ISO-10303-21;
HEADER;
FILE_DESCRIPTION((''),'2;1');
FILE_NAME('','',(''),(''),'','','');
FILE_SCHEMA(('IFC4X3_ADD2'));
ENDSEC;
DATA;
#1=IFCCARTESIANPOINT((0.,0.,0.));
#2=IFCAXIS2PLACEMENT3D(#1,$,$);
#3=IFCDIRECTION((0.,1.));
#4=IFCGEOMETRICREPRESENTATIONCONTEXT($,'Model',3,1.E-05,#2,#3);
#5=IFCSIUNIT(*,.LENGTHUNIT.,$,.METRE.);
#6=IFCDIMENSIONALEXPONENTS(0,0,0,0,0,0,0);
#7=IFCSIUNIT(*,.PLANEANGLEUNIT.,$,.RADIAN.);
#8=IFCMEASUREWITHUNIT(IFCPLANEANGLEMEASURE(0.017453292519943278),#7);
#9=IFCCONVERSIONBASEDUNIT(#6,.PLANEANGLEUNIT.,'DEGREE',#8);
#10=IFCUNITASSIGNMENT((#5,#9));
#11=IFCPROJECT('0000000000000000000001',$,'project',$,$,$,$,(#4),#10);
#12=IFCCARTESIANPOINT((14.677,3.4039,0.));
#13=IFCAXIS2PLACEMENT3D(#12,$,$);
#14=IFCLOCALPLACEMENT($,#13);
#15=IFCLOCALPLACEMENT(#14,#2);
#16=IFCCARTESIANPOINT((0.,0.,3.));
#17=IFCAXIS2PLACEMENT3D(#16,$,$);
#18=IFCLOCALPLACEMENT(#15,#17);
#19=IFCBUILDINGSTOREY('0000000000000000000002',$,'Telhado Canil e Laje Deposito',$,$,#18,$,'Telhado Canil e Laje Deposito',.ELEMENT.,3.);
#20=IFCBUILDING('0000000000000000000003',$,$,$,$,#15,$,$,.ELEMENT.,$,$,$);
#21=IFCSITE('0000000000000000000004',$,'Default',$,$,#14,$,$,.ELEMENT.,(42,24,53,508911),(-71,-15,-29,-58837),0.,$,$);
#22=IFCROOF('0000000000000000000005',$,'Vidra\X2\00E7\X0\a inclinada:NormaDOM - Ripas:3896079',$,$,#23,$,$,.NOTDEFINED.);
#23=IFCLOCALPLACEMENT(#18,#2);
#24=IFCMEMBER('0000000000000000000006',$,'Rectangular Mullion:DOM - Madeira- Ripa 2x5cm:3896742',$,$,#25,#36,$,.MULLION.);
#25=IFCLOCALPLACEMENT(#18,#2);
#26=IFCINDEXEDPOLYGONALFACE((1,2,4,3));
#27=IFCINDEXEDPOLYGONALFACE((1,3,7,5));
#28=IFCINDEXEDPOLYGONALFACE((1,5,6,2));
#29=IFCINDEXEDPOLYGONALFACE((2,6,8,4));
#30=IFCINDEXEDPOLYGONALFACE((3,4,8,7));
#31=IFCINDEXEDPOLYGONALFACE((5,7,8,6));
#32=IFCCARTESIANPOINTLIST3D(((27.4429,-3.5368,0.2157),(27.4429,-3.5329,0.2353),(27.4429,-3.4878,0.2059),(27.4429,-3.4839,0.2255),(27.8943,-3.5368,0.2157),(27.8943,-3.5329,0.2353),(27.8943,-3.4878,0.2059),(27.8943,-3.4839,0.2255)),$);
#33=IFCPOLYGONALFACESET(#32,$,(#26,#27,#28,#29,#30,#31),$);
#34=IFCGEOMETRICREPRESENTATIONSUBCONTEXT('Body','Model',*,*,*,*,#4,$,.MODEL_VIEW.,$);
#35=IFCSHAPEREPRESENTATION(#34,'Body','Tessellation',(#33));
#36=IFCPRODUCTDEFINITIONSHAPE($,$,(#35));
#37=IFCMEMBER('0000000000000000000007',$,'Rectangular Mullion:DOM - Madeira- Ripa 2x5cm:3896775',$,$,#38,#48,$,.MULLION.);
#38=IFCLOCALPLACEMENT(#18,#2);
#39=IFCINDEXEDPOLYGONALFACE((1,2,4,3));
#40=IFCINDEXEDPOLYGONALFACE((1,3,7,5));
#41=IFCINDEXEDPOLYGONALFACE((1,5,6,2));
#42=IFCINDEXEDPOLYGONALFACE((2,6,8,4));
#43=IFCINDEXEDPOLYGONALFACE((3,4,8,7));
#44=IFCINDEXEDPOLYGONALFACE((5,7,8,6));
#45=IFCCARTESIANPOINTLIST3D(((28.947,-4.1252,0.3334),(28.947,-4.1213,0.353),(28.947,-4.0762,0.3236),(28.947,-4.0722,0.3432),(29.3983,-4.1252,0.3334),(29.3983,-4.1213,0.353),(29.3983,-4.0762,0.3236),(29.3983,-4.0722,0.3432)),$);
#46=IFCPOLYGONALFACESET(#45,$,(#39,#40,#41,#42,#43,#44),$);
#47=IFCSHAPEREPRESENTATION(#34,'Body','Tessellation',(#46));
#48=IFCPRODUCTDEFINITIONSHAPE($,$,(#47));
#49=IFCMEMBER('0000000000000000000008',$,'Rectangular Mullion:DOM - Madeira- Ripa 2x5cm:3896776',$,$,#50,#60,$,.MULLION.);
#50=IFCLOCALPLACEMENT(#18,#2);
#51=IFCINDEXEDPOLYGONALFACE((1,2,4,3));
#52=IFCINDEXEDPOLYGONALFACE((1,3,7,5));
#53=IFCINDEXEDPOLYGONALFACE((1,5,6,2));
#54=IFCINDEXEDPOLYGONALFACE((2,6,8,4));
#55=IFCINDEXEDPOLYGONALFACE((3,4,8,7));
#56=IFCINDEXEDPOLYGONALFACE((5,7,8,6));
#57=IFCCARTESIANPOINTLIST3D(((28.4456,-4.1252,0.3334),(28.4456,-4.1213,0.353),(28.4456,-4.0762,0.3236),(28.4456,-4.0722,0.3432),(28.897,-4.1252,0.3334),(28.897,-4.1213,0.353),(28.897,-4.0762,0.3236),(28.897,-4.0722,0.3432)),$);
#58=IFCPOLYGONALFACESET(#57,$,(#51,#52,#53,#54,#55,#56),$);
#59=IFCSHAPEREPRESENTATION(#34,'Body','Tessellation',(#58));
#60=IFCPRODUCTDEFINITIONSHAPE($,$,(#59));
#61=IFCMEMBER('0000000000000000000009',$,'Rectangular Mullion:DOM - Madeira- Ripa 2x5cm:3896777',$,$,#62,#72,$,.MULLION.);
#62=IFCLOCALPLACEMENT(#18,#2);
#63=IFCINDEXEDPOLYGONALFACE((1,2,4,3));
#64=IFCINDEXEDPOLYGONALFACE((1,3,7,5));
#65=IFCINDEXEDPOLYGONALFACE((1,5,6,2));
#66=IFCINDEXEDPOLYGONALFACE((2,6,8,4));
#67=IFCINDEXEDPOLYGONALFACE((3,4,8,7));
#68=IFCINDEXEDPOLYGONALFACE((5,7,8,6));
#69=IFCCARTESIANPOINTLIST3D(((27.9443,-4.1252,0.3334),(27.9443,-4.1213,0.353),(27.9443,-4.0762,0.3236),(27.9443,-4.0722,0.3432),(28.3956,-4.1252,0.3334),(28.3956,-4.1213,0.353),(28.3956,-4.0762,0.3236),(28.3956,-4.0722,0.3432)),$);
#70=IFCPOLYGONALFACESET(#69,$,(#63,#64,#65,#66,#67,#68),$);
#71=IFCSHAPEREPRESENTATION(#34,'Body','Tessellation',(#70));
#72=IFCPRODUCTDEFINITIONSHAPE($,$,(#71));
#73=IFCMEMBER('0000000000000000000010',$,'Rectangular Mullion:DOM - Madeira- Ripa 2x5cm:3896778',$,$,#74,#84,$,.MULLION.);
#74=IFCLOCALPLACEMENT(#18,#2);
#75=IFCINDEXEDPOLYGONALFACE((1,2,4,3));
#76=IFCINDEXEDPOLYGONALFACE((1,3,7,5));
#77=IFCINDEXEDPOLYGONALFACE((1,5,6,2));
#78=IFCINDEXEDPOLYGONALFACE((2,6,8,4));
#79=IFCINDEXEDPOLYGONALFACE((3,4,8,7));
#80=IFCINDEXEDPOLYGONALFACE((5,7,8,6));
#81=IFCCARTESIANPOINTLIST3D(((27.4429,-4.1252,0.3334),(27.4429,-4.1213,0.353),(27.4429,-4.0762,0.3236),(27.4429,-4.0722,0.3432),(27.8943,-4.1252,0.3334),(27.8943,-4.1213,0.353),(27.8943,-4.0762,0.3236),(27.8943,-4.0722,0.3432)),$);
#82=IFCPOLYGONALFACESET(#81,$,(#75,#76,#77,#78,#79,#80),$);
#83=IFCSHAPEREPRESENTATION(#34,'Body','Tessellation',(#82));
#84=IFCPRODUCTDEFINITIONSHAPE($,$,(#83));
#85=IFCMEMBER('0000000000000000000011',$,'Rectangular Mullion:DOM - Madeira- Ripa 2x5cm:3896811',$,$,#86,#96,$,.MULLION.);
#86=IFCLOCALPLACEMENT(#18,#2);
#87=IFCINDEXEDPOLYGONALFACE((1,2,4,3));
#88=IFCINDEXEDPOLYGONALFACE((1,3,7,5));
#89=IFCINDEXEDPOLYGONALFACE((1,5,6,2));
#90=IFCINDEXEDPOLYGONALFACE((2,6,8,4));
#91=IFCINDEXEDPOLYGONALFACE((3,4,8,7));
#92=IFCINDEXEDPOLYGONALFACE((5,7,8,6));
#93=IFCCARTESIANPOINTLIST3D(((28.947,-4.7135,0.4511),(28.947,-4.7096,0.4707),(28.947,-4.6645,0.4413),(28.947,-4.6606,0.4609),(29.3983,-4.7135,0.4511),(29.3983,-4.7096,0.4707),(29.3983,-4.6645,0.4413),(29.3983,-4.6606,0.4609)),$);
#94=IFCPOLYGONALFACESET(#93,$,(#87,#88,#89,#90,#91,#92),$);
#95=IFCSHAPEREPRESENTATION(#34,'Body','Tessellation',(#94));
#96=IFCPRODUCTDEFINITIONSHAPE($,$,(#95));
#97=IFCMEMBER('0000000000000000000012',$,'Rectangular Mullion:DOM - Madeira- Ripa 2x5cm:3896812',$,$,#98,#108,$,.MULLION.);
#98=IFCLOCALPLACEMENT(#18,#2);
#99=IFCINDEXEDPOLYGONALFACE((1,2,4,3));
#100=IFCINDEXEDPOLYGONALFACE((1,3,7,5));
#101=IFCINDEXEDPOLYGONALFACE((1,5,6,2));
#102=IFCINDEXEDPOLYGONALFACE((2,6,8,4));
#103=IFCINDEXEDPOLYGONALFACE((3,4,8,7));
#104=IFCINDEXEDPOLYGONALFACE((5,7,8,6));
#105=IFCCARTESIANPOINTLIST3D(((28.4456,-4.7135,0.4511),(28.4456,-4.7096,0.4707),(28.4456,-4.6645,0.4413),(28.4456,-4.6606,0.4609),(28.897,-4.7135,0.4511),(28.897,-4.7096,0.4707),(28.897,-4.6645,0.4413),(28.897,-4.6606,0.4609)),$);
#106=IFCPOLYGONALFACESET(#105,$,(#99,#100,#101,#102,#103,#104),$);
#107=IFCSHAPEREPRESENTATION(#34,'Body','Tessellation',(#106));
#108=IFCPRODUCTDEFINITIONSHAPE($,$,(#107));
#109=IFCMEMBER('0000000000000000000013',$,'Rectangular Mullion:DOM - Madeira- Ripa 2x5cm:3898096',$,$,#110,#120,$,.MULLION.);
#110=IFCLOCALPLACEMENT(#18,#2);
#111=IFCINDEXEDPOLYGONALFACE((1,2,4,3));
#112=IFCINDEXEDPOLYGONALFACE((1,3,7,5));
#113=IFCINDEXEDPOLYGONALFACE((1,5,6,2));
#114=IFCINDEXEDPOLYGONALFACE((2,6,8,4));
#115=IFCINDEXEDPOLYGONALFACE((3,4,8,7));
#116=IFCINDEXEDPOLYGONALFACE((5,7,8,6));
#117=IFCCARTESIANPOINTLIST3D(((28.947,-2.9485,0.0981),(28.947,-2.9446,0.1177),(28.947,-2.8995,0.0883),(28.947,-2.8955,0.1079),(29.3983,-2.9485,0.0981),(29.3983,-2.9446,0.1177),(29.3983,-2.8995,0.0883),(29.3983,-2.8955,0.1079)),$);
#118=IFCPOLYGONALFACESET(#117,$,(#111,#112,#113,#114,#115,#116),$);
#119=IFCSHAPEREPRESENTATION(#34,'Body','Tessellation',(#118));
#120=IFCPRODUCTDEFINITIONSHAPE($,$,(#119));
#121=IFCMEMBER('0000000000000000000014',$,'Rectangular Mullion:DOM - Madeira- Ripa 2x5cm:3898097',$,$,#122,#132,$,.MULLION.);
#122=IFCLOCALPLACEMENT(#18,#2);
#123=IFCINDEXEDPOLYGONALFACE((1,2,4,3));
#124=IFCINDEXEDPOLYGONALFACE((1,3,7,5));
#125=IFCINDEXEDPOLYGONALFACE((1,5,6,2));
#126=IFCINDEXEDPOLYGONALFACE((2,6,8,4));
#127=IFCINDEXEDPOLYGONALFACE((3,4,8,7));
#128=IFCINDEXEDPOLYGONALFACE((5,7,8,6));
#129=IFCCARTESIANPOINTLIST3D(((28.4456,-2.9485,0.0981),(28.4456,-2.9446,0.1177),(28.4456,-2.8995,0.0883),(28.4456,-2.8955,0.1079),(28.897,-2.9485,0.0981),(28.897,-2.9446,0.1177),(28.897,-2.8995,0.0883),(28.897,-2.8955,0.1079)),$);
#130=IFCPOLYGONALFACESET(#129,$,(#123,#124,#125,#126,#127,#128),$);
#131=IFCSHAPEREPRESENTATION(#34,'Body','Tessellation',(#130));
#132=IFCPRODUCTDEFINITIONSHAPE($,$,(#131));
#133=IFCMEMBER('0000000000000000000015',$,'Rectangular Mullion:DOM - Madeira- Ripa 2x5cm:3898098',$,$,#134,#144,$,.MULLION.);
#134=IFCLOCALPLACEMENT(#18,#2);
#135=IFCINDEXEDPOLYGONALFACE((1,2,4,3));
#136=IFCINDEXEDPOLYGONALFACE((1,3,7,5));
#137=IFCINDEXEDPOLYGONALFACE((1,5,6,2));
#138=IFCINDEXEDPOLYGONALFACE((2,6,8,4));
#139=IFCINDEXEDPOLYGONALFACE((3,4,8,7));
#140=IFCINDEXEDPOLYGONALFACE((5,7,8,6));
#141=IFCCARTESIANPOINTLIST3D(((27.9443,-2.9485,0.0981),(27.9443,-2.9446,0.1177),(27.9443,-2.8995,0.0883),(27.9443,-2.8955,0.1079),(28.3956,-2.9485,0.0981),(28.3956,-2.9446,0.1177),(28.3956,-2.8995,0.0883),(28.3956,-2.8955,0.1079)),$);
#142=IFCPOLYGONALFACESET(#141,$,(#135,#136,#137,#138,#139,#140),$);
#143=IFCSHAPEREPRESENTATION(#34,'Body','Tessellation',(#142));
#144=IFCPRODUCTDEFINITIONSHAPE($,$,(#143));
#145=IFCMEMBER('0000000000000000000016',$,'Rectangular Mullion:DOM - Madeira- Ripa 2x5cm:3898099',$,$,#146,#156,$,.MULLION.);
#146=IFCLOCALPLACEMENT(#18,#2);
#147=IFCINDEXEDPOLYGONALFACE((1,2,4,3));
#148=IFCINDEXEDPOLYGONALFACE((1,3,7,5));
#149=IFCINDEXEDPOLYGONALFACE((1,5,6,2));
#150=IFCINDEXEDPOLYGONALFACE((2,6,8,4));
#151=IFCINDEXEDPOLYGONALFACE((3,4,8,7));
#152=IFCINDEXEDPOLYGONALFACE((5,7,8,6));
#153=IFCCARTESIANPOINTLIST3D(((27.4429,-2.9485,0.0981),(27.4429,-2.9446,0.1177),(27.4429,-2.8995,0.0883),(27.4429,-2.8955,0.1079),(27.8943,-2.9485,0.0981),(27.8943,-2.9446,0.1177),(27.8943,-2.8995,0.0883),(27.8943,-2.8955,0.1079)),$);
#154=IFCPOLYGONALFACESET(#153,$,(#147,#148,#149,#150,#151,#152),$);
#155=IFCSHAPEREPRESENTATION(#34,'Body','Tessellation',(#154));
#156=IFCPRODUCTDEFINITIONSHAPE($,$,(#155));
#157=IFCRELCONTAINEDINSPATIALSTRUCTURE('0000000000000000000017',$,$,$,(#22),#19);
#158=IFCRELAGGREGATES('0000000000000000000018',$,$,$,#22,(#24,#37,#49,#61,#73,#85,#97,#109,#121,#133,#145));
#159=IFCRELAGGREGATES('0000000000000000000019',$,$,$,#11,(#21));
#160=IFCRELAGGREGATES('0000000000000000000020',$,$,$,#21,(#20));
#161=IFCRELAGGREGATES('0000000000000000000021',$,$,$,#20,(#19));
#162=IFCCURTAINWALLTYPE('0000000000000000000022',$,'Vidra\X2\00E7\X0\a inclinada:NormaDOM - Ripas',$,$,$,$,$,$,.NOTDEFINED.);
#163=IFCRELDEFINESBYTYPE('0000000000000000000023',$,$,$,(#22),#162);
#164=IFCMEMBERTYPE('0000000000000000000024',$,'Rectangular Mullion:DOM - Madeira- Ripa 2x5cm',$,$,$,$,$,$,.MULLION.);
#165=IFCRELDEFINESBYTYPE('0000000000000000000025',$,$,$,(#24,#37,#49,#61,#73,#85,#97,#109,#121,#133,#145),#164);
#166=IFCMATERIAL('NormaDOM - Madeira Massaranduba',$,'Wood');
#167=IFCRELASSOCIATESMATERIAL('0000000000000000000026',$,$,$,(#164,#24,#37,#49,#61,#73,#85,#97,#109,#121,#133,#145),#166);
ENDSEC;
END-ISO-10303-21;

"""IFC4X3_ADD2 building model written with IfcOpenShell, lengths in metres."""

from ifc_helpers import new_model, entity, si_unit, converted_unit, direction, frame, origin, origin_2d_with_axis, place, context, subcontext, project, spatial, rectangle, extrude, source, transform, mapped, material, material_profile, profile_set, profile_usage, type_object, type_shapes, element, aggregate, save


model = new_model("IFC4X3_ADD2")

# Units and contexts
model_context = context("Model", 3, precision=1e-05, world=origin(), true_north=direction((0.0, 1.0)))
body_context = subcontext(model_context, "Body", "Model", "MODEL_VIEW")
ifc_project = project(units=[si_unit("LENGTHUNIT", "METRE"), converted_unit("PLANEANGLEUNIT", "DEGREE", entity("IfcPlaneAngleMeasure", 0.017453292519943278), si_unit("PLANEANGLEUNIT", "RADIAN"), dimensions=[0, 0, 0, 0, 0, 0, 0])], contexts=[model_context])

# Site, building, storey
site_placement = place(None, frame((14.677, 3.4039, 0.0)))
site = spatial("IfcSite", under=ifc_project, at=site_placement, Name="Default", CompositionType="ELEMENT", RefLatitude=(42, 24, 53, 508911), RefLongitude=(-71, -15, -29, -58837), RefElevation=0.0)
building_placement = place(site_placement, origin())
building = spatial("IfcBuilding", under=site, at=building_placement, CompositionType="ELEMENT")
storey_placement = place(building_placement, frame((0.0, 0.0, 3.0)))
storey = spatial("IfcBuildingStorey", under=building, at=storey_placement, Name="Telhado Canil e Laje Deposito", LongName="Telhado Canil e Laje Deposito", CompositionType="ELEMENT", Elevation=3.0)

# Roof, members
ifc_material = material(Name="NormaDOM - Madeira Massaranduba", Category="Wood")
ifc_material_profile_1 = material_profile(ifc_material, rectangle(XDim=0.05, YDim=0.02, at=origin_2d_with_axis()), Name="DOM - Madeira- Ripa 2x5cm")
ifc_profile_set_1 = profile_set([ifc_material_profile_1], Name="DOM - Madeira- Ripa 2x5cm")
ifc_profile_usage_1 = profile_usage(ifc_profile_set_1)
curtain_wall_type_1 = type_object("IfcCurtainWallType", Name="Vidraça inclinada:NormaDOM - Ripas", PredefinedType="NOTDEFINED")
roof_1_placement = place(storey_placement, frame((0.0, 0.0, -3.0)))
roof_1 = element("IfcRoof", 1, at=roof_1_placement, inside=storey, type_object=curtain_wall_type_1, Name="Vidraça inclinada:NormaDOM - Ripas:3896079", PredefinedType="NOTDEFINED")
member_type_1 = type_object("IfcMemberType", Name="Rectangular Mullion:DOM - Madeira- Ripa 2x5cm", PredefinedType="MULLION", material=ifc_profile_set_1)
shared_shape_1 = source(origin(), body_context, "Body", "SweptSolid", [
    extrude(rectangle(XDim=0.05, YDim=0.02, at=origin_2d_with_axis()), frame((0.025, 0.01, -0.4514), z_axis=(0.0, 0.0, 1.0), x_axis=(-1.0, 0.0, 0.0)), (0.0, 0.0, 1.0), 0.4514),
])
type_shapes(member_type_1, [shared_shape_1])
member_1_placement = place(roof_1_placement, frame((27.8943, -3.4839, 3.2255), z_axis=(1.0, 0.0, 0.0), x_axis=(0.0, -0.980581, 0.196116)))
member_1 = element("IfcMember", 2, at=member_1_placement, type_object=member_type_1, material=ifc_profile_usage_1, Name="Rectangular Mullion:DOM - Madeira- Ripa 2x5cm:3896742", PredefinedType="MULLION", context=body_context, shape_type="MappedRepresentation", body=[
    mapped(shared_shape_1, transform((0.0, 0.0, 0.0), scale=1.0)),
])
member_2_placement = place(roof_1_placement, frame((29.3983, -4.0722, 3.3432), z_axis=(1.0, 0.0, 0.0), x_axis=(0.0, -0.980581, 0.196116)))
member_2 = element("IfcMember", 3, at=member_2_placement, type_object=member_type_1, material=ifc_profile_usage_1, Name="Rectangular Mullion:DOM - Madeira- Ripa 2x5cm:3896775", PredefinedType="MULLION", context=body_context, shape_type="MappedRepresentation", body=[
    mapped(shared_shape_1, transform((0.0, 0.0, 0.0), scale=1.0)),
])
member_3_placement = place(roof_1_placement, frame((28.897, -4.0722, 3.3432), z_axis=(1.0, 0.0, 0.0), x_axis=(0.0, -0.980581, 0.196116)))
member_3 = element("IfcMember", 4, at=member_3_placement, type_object=member_type_1, material=ifc_profile_usage_1, Name="Rectangular Mullion:DOM - Madeira- Ripa 2x5cm:3896776", PredefinedType="MULLION", context=body_context, shape_type="MappedRepresentation", body=[
    mapped(shared_shape_1, transform((0.0, 0.0, 0.0), scale=1.0)),
])
member_4_placement = place(roof_1_placement, frame((28.3956, -4.0722, 3.3432), z_axis=(1.0, 0.0, 0.0), x_axis=(0.0, -0.980581, 0.196116)))
member_4 = element("IfcMember", 5, at=member_4_placement, type_object=member_type_1, material=ifc_profile_usage_1, Name="Rectangular Mullion:DOM - Madeira- Ripa 2x5cm:3896777", PredefinedType="MULLION", context=body_context, shape_type="MappedRepresentation", body=[
    mapped(shared_shape_1, transform((0.0, 0.0, 0.0), scale=1.0)),
])
member_5_placement = place(roof_1_placement, frame((27.8943, -4.0722, 3.3432), z_axis=(1.0, 0.0, 0.0), x_axis=(0.0, -0.980581, 0.196116)))
member_5 = element("IfcMember", 6, at=member_5_placement, type_object=member_type_1, material=ifc_profile_usage_1, Name="Rectangular Mullion:DOM - Madeira- Ripa 2x5cm:3896778", PredefinedType="MULLION", context=body_context, shape_type="MappedRepresentation", body=[
    mapped(shared_shape_1, transform((0.0, 0.0, 0.0), scale=1.0)),
])
member_6_placement = place(roof_1_placement, frame((29.3983, -4.6606, 3.4609), z_axis=(1.0, 0.0, 0.0), x_axis=(0.0, -0.980581, 0.196116)))
member_6 = element("IfcMember", 7, at=member_6_placement, type_object=member_type_1, material=ifc_profile_usage_1, Name="Rectangular Mullion:DOM - Madeira- Ripa 2x5cm:3896811", PredefinedType="MULLION", context=body_context, shape_type="MappedRepresentation", body=[
    mapped(shared_shape_1, transform((0.0, 0.0, 0.0), scale=1.0)),
])
member_7_placement = place(roof_1_placement, frame((28.897, -4.6606, 3.4609), z_axis=(1.0, 0.0, 0.0), x_axis=(0.0, -0.980581, 0.196116)))
member_7 = element("IfcMember", 8, at=member_7_placement, type_object=member_type_1, material=ifc_profile_usage_1, Name="Rectangular Mullion:DOM - Madeira- Ripa 2x5cm:3896812", PredefinedType="MULLION", context=body_context, shape_type="MappedRepresentation", body=[
    mapped(shared_shape_1, transform((0.0, 0.0, 0.0), scale=1.0)),
])
member_8_placement = place(roof_1_placement, frame((29.3983, -2.8955, 3.1079), z_axis=(1.0, 0.0, 0.0), x_axis=(0.0, -0.980581, 0.196116)))
member_8 = element("IfcMember", 9, at=member_8_placement, type_object=member_type_1, material=ifc_profile_usage_1, Name="Rectangular Mullion:DOM - Madeira- Ripa 2x5cm:3898096", PredefinedType="MULLION", context=body_context, shape_type="MappedRepresentation", body=[
    mapped(shared_shape_1, transform((0.0, 0.0, 0.0), scale=1.0)),
])
member_9_placement = place(roof_1_placement, frame((28.897, -2.8955, 3.1079), z_axis=(1.0, 0.0, 0.0), x_axis=(0.0, -0.980581, 0.196116)))
member_9 = element("IfcMember", 10, at=member_9_placement, type_object=member_type_1, material=ifc_profile_usage_1, Name="Rectangular Mullion:DOM - Madeira- Ripa 2x5cm:3898097", PredefinedType="MULLION", context=body_context, shape_type="MappedRepresentation", body=[
    mapped(shared_shape_1, transform((0.0, 0.0, 0.0), scale=1.0)),
])
member_10_placement = place(roof_1_placement, frame((28.3956, -2.8955, 3.1079), z_axis=(1.0, 0.0, 0.0), x_axis=(0.0, -0.980581, 0.196116)))
member_10 = element("IfcMember", 11, at=member_10_placement, type_object=member_type_1, material=ifc_profile_usage_1, Name="Rectangular Mullion:DOM - Madeira- Ripa 2x5cm:3898098", PredefinedType="MULLION", context=body_context, shape_type="MappedRepresentation", body=[
    mapped(shared_shape_1, transform((0.0, 0.0, 0.0), scale=1.0)),
])
member_11_placement = place(roof_1_placement, frame((27.8943, -2.8955, 3.1079), z_axis=(1.0, 0.0, 0.0), x_axis=(0.0, -0.980581, 0.196116)))
member_11 = element("IfcMember", 12, at=member_11_placement, type_object=member_type_1, material=ifc_profile_usage_1, Name="Rectangular Mullion:DOM - Madeira- Ripa 2x5cm:3898099", PredefinedType="MULLION", context=body_context, shape_type="MappedRepresentation", body=[
    mapped(shared_shape_1, transform((0.0, 0.0, 0.0), scale=1.0)),
])
aggregate(roof_1, [member_1, member_2, member_3, member_4, member_5, member_6, member_7, member_8, member_9, member_10, member_11])

save(model, "model.ifc")
